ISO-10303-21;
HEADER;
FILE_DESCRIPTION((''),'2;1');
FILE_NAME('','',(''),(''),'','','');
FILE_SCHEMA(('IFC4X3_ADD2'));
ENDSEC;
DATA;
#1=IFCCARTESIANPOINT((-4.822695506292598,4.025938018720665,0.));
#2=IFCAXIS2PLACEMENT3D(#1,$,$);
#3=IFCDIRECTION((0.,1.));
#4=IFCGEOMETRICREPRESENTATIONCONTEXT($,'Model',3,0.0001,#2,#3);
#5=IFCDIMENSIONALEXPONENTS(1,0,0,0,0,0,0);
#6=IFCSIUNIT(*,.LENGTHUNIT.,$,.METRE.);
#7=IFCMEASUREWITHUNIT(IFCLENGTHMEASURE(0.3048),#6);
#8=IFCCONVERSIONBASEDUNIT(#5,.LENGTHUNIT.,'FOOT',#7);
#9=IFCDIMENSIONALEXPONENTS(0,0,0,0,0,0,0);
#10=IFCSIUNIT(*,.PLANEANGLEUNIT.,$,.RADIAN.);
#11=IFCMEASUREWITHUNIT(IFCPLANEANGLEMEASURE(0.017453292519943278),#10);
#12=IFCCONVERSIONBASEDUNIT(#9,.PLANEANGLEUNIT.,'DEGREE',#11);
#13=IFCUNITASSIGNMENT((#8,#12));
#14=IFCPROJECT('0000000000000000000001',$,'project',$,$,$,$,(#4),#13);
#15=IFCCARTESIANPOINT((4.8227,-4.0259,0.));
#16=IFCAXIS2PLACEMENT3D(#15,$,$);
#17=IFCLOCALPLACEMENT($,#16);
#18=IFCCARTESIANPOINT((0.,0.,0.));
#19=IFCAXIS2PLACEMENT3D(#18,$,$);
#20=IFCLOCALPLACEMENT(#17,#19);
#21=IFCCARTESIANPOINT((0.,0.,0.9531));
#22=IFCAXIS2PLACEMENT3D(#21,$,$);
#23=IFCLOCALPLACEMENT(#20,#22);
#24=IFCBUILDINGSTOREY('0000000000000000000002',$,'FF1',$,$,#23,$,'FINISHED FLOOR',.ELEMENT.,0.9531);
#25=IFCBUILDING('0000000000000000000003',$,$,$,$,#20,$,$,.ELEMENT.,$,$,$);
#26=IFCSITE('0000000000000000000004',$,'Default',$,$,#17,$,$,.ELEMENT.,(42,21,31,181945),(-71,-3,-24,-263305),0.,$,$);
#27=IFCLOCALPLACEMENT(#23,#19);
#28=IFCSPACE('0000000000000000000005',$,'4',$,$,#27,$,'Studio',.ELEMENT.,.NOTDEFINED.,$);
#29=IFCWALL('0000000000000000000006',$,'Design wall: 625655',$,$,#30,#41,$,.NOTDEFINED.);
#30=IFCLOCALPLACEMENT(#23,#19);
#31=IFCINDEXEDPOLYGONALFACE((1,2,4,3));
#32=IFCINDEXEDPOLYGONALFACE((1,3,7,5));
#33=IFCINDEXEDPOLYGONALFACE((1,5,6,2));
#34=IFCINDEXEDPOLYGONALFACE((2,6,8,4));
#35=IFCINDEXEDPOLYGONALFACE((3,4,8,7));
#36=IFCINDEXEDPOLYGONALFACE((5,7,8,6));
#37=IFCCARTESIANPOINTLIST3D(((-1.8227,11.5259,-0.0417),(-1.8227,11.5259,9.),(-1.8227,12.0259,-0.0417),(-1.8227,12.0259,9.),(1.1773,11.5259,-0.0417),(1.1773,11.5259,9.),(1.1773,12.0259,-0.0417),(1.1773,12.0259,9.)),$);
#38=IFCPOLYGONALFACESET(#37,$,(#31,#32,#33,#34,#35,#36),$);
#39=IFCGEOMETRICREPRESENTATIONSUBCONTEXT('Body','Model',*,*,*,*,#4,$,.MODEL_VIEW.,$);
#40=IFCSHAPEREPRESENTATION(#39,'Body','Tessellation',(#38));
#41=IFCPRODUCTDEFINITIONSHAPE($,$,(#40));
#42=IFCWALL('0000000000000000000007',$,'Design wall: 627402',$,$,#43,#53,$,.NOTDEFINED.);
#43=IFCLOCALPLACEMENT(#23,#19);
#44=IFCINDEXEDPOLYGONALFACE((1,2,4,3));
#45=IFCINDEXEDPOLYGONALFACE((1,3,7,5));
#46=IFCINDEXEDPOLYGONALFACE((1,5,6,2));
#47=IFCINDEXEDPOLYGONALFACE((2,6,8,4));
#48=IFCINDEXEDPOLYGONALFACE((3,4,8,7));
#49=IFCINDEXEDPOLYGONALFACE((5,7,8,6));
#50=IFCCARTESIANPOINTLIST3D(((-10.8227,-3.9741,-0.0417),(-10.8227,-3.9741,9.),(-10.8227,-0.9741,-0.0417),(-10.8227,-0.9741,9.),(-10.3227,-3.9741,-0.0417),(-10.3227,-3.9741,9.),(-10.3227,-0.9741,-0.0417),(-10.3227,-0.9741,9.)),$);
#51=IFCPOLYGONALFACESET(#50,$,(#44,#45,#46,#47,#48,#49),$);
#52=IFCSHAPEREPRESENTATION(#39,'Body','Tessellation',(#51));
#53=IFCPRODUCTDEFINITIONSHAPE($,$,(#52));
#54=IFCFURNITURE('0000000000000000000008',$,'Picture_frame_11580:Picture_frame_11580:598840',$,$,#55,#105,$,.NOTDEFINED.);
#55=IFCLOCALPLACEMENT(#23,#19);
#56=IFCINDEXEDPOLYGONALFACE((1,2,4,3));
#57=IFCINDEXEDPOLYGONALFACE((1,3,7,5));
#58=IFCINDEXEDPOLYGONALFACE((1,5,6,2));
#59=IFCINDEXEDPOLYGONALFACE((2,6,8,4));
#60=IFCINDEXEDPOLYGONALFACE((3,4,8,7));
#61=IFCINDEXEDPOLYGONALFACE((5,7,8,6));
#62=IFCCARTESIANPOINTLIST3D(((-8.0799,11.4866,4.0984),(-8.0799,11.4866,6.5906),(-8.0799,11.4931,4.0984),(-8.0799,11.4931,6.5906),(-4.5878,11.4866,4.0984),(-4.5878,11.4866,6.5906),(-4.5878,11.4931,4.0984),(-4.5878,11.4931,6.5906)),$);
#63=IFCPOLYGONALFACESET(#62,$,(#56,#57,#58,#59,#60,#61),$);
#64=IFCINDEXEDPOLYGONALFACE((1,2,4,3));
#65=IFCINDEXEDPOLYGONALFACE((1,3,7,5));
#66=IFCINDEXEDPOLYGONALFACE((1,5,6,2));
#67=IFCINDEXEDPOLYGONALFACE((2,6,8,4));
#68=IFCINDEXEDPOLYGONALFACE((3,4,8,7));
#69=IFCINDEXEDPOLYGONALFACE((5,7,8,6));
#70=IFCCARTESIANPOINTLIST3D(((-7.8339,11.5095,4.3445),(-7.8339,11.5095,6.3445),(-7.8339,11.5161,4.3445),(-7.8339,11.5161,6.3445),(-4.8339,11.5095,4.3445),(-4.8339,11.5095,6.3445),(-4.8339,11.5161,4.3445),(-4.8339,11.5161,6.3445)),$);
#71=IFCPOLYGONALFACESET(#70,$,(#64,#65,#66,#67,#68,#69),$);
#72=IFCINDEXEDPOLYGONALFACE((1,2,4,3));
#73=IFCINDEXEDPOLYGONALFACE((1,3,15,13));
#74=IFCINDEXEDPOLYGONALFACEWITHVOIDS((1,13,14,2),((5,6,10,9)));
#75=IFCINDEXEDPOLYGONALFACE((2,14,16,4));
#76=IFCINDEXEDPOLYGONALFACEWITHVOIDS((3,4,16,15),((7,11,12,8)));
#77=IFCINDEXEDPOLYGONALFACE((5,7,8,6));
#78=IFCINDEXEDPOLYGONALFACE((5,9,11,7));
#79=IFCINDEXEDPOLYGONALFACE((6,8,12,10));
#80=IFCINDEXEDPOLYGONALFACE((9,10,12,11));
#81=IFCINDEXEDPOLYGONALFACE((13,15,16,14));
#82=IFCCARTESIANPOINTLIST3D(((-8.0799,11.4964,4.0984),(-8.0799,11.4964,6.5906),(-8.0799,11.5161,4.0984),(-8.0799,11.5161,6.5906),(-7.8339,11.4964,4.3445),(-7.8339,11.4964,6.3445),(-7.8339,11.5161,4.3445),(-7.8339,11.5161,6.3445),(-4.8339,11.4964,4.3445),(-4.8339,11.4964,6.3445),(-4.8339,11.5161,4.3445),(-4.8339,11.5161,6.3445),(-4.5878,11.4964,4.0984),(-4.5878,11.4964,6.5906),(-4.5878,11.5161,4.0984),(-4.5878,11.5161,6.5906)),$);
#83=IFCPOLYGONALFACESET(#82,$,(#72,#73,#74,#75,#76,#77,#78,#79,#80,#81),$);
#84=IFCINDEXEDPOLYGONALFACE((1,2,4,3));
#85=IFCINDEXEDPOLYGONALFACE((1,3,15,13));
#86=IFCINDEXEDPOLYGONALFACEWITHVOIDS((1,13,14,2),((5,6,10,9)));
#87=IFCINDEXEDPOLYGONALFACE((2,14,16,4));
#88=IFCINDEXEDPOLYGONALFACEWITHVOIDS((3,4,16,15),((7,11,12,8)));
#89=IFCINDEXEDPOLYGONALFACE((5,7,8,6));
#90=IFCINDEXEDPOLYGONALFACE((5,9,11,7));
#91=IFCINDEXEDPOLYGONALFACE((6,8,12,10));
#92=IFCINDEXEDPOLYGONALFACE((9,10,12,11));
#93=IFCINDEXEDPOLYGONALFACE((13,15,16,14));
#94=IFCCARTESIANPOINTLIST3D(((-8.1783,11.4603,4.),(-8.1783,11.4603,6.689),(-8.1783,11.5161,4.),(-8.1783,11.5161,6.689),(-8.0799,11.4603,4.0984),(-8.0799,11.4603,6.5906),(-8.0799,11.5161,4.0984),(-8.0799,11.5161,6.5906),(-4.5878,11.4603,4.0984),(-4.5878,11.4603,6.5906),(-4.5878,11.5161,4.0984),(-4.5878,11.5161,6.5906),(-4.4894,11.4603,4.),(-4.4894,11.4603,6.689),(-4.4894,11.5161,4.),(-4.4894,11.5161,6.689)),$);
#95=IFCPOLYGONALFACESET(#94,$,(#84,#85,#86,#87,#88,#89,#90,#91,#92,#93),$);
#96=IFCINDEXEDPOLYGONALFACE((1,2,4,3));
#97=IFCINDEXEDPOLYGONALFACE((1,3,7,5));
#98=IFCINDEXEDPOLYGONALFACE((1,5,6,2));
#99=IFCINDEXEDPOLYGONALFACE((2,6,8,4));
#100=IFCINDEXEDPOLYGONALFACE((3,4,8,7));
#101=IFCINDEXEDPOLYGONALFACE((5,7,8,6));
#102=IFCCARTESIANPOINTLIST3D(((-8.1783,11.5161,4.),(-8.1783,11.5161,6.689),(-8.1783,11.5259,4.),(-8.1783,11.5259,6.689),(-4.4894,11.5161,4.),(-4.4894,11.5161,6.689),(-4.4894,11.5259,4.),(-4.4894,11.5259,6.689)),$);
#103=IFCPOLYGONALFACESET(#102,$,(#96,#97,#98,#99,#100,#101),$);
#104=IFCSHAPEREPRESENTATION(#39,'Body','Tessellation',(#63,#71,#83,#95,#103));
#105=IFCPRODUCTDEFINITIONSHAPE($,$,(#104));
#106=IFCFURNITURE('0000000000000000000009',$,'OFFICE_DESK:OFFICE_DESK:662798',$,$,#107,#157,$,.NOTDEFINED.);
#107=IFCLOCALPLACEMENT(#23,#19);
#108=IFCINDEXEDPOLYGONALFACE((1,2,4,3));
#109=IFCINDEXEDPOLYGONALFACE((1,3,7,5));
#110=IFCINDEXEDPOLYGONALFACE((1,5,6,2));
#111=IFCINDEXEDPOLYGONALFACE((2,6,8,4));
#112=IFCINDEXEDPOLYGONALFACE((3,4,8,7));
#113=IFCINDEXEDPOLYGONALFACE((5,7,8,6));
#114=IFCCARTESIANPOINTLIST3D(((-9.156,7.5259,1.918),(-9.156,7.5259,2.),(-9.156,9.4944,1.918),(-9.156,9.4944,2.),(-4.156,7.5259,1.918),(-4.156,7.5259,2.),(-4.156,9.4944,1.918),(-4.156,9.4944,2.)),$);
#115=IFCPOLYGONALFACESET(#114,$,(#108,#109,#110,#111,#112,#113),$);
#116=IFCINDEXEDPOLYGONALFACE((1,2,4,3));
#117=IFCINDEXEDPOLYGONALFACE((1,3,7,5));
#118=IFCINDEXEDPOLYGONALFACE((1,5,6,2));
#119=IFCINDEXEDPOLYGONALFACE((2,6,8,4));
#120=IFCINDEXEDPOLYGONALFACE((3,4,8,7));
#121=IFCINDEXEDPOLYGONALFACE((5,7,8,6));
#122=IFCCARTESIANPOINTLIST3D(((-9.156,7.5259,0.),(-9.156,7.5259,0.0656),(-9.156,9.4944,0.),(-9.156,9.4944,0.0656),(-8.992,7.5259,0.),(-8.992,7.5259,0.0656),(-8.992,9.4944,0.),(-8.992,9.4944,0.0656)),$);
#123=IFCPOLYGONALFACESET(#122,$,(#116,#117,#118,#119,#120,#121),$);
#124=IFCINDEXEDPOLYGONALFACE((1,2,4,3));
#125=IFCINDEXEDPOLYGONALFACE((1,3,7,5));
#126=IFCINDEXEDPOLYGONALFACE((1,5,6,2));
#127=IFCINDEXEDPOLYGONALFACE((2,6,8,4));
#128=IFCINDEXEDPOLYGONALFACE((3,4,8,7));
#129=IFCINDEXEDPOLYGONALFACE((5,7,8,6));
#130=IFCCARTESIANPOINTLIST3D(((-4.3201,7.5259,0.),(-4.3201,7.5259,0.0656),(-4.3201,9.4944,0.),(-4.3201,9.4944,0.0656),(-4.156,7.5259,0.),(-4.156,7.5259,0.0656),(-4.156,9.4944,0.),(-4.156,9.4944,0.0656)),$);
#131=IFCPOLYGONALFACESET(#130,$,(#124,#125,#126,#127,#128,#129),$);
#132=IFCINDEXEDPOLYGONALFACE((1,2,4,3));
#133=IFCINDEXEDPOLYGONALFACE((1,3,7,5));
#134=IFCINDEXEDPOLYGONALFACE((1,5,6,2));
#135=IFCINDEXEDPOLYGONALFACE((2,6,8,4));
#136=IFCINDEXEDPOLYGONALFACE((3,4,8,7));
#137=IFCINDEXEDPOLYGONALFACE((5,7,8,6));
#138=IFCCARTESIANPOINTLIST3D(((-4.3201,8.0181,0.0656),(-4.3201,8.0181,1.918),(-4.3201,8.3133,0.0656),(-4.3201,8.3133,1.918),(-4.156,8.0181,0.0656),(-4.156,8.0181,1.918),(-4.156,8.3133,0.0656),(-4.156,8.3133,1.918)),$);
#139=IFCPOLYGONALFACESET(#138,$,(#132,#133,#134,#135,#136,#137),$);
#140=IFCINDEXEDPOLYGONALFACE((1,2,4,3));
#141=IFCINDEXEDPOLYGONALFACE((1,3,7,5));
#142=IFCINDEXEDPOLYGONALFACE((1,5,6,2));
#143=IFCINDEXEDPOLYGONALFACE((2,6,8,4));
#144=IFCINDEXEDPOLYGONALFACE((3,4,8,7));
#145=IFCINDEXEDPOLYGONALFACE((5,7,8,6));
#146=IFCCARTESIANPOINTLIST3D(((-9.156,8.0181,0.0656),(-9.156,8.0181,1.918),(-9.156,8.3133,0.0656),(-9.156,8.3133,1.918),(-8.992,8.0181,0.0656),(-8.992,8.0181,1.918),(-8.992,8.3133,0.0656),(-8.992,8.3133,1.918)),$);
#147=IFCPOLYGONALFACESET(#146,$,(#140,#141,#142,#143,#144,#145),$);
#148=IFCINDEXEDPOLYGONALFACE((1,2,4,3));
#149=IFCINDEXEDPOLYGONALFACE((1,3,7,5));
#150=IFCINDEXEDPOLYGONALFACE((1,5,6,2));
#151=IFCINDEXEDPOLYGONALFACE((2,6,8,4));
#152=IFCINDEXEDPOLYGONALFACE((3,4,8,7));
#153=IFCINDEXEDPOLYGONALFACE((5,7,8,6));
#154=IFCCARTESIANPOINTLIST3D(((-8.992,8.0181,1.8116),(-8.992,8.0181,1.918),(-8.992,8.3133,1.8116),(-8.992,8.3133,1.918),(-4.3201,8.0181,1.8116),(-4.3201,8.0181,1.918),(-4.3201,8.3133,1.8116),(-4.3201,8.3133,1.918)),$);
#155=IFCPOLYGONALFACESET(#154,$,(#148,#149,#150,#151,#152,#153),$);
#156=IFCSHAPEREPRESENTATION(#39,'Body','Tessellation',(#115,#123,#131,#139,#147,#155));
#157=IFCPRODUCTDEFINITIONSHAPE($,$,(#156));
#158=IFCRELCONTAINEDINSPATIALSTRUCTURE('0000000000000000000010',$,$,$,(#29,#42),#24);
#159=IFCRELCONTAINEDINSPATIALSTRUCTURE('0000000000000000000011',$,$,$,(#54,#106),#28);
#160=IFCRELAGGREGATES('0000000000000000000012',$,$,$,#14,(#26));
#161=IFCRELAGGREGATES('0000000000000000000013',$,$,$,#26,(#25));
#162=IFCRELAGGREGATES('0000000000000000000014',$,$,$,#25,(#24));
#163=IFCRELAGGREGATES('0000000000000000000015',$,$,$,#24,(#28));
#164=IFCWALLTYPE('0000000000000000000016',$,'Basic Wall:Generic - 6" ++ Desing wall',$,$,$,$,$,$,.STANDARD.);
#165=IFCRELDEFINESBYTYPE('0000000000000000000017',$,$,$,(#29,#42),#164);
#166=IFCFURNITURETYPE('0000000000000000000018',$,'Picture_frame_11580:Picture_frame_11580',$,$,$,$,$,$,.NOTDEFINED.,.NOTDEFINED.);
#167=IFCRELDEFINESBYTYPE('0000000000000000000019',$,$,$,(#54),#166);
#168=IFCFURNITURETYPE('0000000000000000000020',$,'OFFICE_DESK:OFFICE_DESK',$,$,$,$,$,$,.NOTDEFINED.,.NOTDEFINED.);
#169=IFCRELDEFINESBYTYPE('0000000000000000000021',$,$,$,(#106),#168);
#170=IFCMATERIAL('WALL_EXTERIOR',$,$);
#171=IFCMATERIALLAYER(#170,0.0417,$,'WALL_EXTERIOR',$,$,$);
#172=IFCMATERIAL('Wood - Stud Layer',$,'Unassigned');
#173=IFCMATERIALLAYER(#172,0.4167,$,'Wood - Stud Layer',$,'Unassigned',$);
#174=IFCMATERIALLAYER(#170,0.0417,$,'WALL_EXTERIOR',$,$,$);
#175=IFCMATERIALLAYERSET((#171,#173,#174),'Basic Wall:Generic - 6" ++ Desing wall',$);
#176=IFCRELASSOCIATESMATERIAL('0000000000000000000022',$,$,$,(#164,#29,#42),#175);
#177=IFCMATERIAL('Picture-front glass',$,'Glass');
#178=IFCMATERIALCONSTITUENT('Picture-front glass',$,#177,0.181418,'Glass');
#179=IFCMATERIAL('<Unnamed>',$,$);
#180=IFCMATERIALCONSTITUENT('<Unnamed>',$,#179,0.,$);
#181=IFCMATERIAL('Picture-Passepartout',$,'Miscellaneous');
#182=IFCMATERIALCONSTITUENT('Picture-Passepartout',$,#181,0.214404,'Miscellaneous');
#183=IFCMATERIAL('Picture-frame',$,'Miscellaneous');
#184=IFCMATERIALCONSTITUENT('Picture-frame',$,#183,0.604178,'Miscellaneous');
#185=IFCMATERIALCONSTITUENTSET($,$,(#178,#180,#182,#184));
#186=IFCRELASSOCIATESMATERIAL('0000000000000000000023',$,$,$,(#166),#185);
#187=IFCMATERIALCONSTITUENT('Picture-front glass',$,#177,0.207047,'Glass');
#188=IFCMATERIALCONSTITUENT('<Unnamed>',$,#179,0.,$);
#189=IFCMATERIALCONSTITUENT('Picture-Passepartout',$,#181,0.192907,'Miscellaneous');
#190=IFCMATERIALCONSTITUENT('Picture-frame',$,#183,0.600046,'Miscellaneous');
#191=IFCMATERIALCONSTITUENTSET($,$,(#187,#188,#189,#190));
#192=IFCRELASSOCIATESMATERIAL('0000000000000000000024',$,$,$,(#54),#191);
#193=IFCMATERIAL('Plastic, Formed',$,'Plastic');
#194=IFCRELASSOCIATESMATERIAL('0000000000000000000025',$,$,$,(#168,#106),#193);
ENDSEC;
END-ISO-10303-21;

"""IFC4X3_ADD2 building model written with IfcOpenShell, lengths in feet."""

from ifc_helpers import new_model, entity, si_unit, converted_unit, direction, frame, frame_2d, origin, origin_2d_with_axis, place, context, subcontext, project, spatial, polyline, rectangle, outline, extrude, source, transform, mapped, material, layer, layer_set, constituent, constituent_set, type_object, type_shapes, element, save


model = new_model("IFC4X3_ADD2")

# Units and contexts
model_context = context("Model", 3, precision=0.0001, world=frame((-4.822695506292598, 4.025938018720665, 0.0)), true_north=direction((0.0, 1.0)))
body_context = subcontext(model_context, "Body", "Model", "MODEL_VIEW")
ifc_project = project(units=[converted_unit("LENGTHUNIT", "FOOT", entity("IfcLengthMeasure", 0.3048), si_unit("LENGTHUNIT", "METRE"), dimensions=[1, 0, 0, 0, 0, 0, 0]), converted_unit("PLANEANGLEUNIT", "DEGREE", entity("IfcPlaneAngleMeasure", 0.017453292519943278), si_unit("PLANEANGLEUNIT", "RADIAN"), dimensions=[0, 0, 0, 0, 0, 0, 0])], contexts=[model_context])

# Site, building, storey
site_placement = place(None, frame((4.8227, -4.0259, 0.0)))
site = spatial("IfcSite", under=ifc_project, at=site_placement, Name="Default", CompositionType="ELEMENT", RefLatitude=(42, 21, 31, 181945), RefLongitude=(-71, -3, -24, -263305), RefElevation=0.0)
building_placement = place(site_placement, origin())
building = spatial("IfcBuilding", under=site, at=building_placement, CompositionType="ELEMENT")
storey_placement = place(building_placement, frame((0.0, 0.0, 0.9531)))
storey = spatial("IfcBuildingStorey", under=building, at=storey_placement, Name="FF1", LongName="FINISHED FLOOR", CompositionType="ELEMENT", Elevation=0.9531)

# Shared definitions
ifc_material_1 = material(Name="WALL_EXTERIOR")
ifc_material_2 = material(Name="Wood - Stud Layer", Category="Unassigned")

# Walls
ifc_layer_1 = layer(ifc_material_1, 0.0417, Name="WALL_EXTERIOR")
ifc_layer_2 = layer(ifc_material_2, 0.4167, Name="Wood - Stud Layer", Category="Unassigned")
ifc_layer_3 = layer(ifc_material_1, 0.0417, Name="WALL_EXTERIOR")
ifc_layer_set_1 = layer_set([ifc_layer_1, ifc_layer_2, ifc_layer_3], Name="Basic Wall:Generic - 6\" ++ Desing wall")
wall_type_1 = type_object("IfcWallType", Name="Basic Wall:Generic - 6\" ++ Desing wall", PredefinedType="STANDARD", material=ifc_layer_set_1)
wall_1_placement = place(storey_placement, frame((-1.8227, 11.7759, -0.0417)))
element("IfcWall", 1, at=wall_1_placement, inside=storey, type_object=wall_type_1, material=ifc_layer_set_1, Name="Design wall: 625655", PredefinedType="NOTDEFINED", context=body_context, shape_type="SweptSolid", body=[
    extrude(rectangle(XDim=3.0, YDim=0.5, at=frame_2d((1.5, 0.0), x_axis=(-1.0, 0.0))), origin(), (0.0, 0.0, 1.0), 9.0417),
])
wall_2_placement = place(storey_placement, frame((-10.5727, -0.9741, -0.0417), z_axis=(0.0, 0.0, 1.0), x_axis=(0.0, -1.0, 0.0)))
element("IfcWall", 2, at=wall_2_placement, inside=storey, type_object=wall_type_1, material=ifc_layer_set_1, Name="Design wall: 627402", PredefinedType="NOTDEFINED", context=body_context, shape_type="SweptSolid", body=[
    extrude(rectangle(XDim=3.0, YDim=0.5, at=frame_2d((1.5, 0.0), x_axis=(-1.0, 0.0))), origin(), (0.0, 0.0, 1.0), 9.0417),
])

# Shared definitions
space_placement = place(storey_placement, origin())
space = spatial("IfcSpace", under=storey, at=space_placement, Name="4", LongName="Studio", CompositionType="ELEMENT", PredefinedType="NOTDEFINED")

# Furniture
ifc_material_3 = material(Name="Picture-front glass", Category="Glass")
ifc_constituent_1 = constituent(ifc_material_3, Name="Picture-front glass", Category="Glass", fraction=0.207047)
ifc_material_4 = material(Name="<Unnamed>")
ifc_constituent_2 = constituent(ifc_material_4, Name="<Unnamed>", fraction=0.0)
ifc_material_5 = material(Name="Picture-Passepartout", Category="Miscellaneous")
ifc_constituent_3 = constituent(ifc_material_5, Name="Picture-Passepartout", Category="Miscellaneous", fraction=0.192907)
ifc_material_6 = material(Name="Picture-frame", Category="Miscellaneous")
ifc_constituent_4 = constituent(ifc_material_6, Name="Picture-frame", Category="Miscellaneous", fraction=0.600046)
ifc_constituent_set_1 = constituent_set(constituents=[ifc_constituent_1, ifc_constituent_2, ifc_constituent_3, ifc_constituent_4])
ifc_constituent_5 = constituent(ifc_material_3, Name="Picture-front glass", Category="Glass", fraction=0.181418)
ifc_constituent_6 = constituent(ifc_material_4, Name="<Unnamed>", fraction=0.0)
ifc_constituent_7 = constituent(ifc_material_5, Name="Picture-Passepartout", Category="Miscellaneous", fraction=0.214404)
ifc_constituent_8 = constituent(ifc_material_6, Name="Picture-frame", Category="Miscellaneous", fraction=0.604178)
ifc_constituent_set_2 = constituent_set(constituents=[ifc_constituent_5, ifc_constituent_6, ifc_constituent_7, ifc_constituent_8])
furniture_type_1 = type_object("IfcFurnitureType", Name="Picture_frame_11580:Picture_frame_11580", AssemblyPlace="NOTDEFINED", PredefinedType="NOTDEFINED", material=ifc_constituent_set_2)
shared_shape_1 = source(origin(), body_context, "Body", "SweptSolid", [
    extrude(rectangle(XDim=0.0066, YDim=3.4921, at=frame_2d((0.0, 0.0), x_axis=(1.0, 0.0))), frame((1.8445, -0.0361, 0.0984), z_axis=(0.0, 0.0, 1.0), x_axis=(0.0, 1.0, 0.0)), (0.0, 0.0, 1.0), 2.4921),
    extrude(rectangle(XDim=0.0066, YDim=3.0, at=origin_2d_with_axis()), frame((1.8445, -0.0131, 0.3445), z_axis=(0.0, 0.0, 1.0), x_axis=(0.0, 1.0, 0.0)), (0.0, 0.0, 1.0), 2.0),
    extrude(outline(polyline([(-1.2461, -1.7461), (1.2461, -1.7461), (1.2461, 1.7461), (-1.2461, 1.7461), (-1.2461, -1.7461)]), holes=[polyline([(-1.0, -1.5), (-1.0, 1.5), (1.0, 1.5), (1.0, -1.5), (-1.0, -1.5)])]), frame((1.8445, -0.0295, 1.3445), z_axis=(0.0, 1.0, 0.0), x_axis=(0.0, 0.0, -1.0)), (0.0, 0.0, 1.0), 0.0197),
    extrude(outline(polyline([(-1.8445, -1.3445), (1.8445, -1.3445), (1.8445, 1.3445), (-1.8445, 1.3445), (-1.8445, -1.3445)]), holes=[polyline([(1.7461, -1.2461), (-1.7461, -1.2461), (-1.7461, 1.2461), (1.7461, 1.2461), (1.7461, -1.2461)])]), frame((1.8445, -0.0656, 1.3445), z_axis=(0.0, 1.0, 0.0), x_axis=(1.0, 0.0, 0.0)), (0.0, 0.0, 1.0), 0.0558),
    extrude(rectangle(XDim=0.0098, YDim=3.689, at=origin_2d_with_axis()), frame((1.8445, -0.0049, 0.0), z_axis=(0.0, 0.0, 1.0), x_axis=(0.0, 1.0, 0.0)), (0.0, 0.0, 1.0), 2.689),
])
type_shapes(furniture_type_1, [shared_shape_1])
furniture_1_placement = place(space_placement, frame((-8.1783, 11.5259, 4.0)))
element("IfcFurniture", 3, at=furniture_1_placement, inside=space, type_object=furniture_type_1, material=ifc_constituent_set_1, Name="Picture_frame_11580:Picture_frame_11580:598840", PredefinedType="NOTDEFINED", context=body_context, shape_type="MappedRepresentation", body=[
    mapped(shared_shape_1, transform((0.0, 0.0, 0.0), scale=1.0)),
])
ifc_material_7 = material(Name="Plastic, Formed", Category="Plastic")
furniture_type_2 = type_object("IfcFurnitureType", Name="OFFICE_DESK:OFFICE_DESK", AssemblyPlace="NOTDEFINED", PredefinedType="NOTDEFINED", material=ifc_material_7)
shared_shape_2 = source(origin(), body_context, "Body", "SweptSolid", [
    extrude(rectangle(XDim=1.9685, YDim=5.0, at=origin_2d_with_axis()), frame((0.0, -0.9843, 1.918), z_axis=(0.0, 0.0, 1.0), x_axis=(0.0, -1.0, 0.0)), (0.0, 0.0, 1.0), 0.082),
    extrude(rectangle(XDim=0.164, YDim=1.9685, at=origin_2d_with_axis()), frame((2.418, -0.9843, 0.0)), (0.0, 0.0, 1.0), 0.0656),
    extrude(rectangle(XDim=1.9685, YDim=0.164, at=origin_2d_with_axis()), frame((-2.418, -0.9843, 0.0), z_axis=(0.0, 0.0, 1.0), x_axis=(0.0, 1.0, 0.0)), (0.0, 0.0, 1.0), 0.0656),
    extrude(rectangle(XDim=0.2953, YDim=0.164, at=frame_2d((0.0, 0.0), x_axis=(1.0, 0.0))), frame((-2.418, -0.6398, 0.0656), z_axis=(0.0, 0.0, 1.0), x_axis=(0.0, -1.0, 0.0)), (0.0, 0.0, 1.0), 1.8524),
    extrude(rectangle(XDim=0.164, YDim=0.2953, at=origin_2d_with_axis()), frame((2.418, -0.6398, 0.0656), z_axis=(0.0, 0.0, 1.0), x_axis=(-1.0, 0.0, 0.0)), (0.0, 0.0, 1.0), 1.8524),
    extrude(rectangle(XDim=0.2953, YDim=4.6719, at=origin_2d_with_axis()), frame((0.0, -0.6398, 1.8116), z_axis=(0.0, 0.0, 1.0), x_axis=(0.0, 1.0, 0.0)), (0.0, 0.0, 1.0), 0.1064),
])
type_shapes(furniture_type_2, [shared_shape_2])
furniture_2_placement = place(space_placement, frame((-6.656, 7.5259, 0.0), z_axis=(0.0, 0.0, 1.0), x_axis=(-1.0, 0.0, 0.0)))
element("IfcFurniture", 4, at=furniture_2_placement, inside=space, type_object=furniture_type_2, material=ifc_material_7, Name="OFFICE_DESK:OFFICE_DESK:662798", PredefinedType="NOTDEFINED", context=body_context, shape_type="MappedRepresentation", body=[
    mapped(shared_shape_2, transform((0.0, 0.0, 0.0), scale=1.0)),
])

save(model, "model.ifc")
